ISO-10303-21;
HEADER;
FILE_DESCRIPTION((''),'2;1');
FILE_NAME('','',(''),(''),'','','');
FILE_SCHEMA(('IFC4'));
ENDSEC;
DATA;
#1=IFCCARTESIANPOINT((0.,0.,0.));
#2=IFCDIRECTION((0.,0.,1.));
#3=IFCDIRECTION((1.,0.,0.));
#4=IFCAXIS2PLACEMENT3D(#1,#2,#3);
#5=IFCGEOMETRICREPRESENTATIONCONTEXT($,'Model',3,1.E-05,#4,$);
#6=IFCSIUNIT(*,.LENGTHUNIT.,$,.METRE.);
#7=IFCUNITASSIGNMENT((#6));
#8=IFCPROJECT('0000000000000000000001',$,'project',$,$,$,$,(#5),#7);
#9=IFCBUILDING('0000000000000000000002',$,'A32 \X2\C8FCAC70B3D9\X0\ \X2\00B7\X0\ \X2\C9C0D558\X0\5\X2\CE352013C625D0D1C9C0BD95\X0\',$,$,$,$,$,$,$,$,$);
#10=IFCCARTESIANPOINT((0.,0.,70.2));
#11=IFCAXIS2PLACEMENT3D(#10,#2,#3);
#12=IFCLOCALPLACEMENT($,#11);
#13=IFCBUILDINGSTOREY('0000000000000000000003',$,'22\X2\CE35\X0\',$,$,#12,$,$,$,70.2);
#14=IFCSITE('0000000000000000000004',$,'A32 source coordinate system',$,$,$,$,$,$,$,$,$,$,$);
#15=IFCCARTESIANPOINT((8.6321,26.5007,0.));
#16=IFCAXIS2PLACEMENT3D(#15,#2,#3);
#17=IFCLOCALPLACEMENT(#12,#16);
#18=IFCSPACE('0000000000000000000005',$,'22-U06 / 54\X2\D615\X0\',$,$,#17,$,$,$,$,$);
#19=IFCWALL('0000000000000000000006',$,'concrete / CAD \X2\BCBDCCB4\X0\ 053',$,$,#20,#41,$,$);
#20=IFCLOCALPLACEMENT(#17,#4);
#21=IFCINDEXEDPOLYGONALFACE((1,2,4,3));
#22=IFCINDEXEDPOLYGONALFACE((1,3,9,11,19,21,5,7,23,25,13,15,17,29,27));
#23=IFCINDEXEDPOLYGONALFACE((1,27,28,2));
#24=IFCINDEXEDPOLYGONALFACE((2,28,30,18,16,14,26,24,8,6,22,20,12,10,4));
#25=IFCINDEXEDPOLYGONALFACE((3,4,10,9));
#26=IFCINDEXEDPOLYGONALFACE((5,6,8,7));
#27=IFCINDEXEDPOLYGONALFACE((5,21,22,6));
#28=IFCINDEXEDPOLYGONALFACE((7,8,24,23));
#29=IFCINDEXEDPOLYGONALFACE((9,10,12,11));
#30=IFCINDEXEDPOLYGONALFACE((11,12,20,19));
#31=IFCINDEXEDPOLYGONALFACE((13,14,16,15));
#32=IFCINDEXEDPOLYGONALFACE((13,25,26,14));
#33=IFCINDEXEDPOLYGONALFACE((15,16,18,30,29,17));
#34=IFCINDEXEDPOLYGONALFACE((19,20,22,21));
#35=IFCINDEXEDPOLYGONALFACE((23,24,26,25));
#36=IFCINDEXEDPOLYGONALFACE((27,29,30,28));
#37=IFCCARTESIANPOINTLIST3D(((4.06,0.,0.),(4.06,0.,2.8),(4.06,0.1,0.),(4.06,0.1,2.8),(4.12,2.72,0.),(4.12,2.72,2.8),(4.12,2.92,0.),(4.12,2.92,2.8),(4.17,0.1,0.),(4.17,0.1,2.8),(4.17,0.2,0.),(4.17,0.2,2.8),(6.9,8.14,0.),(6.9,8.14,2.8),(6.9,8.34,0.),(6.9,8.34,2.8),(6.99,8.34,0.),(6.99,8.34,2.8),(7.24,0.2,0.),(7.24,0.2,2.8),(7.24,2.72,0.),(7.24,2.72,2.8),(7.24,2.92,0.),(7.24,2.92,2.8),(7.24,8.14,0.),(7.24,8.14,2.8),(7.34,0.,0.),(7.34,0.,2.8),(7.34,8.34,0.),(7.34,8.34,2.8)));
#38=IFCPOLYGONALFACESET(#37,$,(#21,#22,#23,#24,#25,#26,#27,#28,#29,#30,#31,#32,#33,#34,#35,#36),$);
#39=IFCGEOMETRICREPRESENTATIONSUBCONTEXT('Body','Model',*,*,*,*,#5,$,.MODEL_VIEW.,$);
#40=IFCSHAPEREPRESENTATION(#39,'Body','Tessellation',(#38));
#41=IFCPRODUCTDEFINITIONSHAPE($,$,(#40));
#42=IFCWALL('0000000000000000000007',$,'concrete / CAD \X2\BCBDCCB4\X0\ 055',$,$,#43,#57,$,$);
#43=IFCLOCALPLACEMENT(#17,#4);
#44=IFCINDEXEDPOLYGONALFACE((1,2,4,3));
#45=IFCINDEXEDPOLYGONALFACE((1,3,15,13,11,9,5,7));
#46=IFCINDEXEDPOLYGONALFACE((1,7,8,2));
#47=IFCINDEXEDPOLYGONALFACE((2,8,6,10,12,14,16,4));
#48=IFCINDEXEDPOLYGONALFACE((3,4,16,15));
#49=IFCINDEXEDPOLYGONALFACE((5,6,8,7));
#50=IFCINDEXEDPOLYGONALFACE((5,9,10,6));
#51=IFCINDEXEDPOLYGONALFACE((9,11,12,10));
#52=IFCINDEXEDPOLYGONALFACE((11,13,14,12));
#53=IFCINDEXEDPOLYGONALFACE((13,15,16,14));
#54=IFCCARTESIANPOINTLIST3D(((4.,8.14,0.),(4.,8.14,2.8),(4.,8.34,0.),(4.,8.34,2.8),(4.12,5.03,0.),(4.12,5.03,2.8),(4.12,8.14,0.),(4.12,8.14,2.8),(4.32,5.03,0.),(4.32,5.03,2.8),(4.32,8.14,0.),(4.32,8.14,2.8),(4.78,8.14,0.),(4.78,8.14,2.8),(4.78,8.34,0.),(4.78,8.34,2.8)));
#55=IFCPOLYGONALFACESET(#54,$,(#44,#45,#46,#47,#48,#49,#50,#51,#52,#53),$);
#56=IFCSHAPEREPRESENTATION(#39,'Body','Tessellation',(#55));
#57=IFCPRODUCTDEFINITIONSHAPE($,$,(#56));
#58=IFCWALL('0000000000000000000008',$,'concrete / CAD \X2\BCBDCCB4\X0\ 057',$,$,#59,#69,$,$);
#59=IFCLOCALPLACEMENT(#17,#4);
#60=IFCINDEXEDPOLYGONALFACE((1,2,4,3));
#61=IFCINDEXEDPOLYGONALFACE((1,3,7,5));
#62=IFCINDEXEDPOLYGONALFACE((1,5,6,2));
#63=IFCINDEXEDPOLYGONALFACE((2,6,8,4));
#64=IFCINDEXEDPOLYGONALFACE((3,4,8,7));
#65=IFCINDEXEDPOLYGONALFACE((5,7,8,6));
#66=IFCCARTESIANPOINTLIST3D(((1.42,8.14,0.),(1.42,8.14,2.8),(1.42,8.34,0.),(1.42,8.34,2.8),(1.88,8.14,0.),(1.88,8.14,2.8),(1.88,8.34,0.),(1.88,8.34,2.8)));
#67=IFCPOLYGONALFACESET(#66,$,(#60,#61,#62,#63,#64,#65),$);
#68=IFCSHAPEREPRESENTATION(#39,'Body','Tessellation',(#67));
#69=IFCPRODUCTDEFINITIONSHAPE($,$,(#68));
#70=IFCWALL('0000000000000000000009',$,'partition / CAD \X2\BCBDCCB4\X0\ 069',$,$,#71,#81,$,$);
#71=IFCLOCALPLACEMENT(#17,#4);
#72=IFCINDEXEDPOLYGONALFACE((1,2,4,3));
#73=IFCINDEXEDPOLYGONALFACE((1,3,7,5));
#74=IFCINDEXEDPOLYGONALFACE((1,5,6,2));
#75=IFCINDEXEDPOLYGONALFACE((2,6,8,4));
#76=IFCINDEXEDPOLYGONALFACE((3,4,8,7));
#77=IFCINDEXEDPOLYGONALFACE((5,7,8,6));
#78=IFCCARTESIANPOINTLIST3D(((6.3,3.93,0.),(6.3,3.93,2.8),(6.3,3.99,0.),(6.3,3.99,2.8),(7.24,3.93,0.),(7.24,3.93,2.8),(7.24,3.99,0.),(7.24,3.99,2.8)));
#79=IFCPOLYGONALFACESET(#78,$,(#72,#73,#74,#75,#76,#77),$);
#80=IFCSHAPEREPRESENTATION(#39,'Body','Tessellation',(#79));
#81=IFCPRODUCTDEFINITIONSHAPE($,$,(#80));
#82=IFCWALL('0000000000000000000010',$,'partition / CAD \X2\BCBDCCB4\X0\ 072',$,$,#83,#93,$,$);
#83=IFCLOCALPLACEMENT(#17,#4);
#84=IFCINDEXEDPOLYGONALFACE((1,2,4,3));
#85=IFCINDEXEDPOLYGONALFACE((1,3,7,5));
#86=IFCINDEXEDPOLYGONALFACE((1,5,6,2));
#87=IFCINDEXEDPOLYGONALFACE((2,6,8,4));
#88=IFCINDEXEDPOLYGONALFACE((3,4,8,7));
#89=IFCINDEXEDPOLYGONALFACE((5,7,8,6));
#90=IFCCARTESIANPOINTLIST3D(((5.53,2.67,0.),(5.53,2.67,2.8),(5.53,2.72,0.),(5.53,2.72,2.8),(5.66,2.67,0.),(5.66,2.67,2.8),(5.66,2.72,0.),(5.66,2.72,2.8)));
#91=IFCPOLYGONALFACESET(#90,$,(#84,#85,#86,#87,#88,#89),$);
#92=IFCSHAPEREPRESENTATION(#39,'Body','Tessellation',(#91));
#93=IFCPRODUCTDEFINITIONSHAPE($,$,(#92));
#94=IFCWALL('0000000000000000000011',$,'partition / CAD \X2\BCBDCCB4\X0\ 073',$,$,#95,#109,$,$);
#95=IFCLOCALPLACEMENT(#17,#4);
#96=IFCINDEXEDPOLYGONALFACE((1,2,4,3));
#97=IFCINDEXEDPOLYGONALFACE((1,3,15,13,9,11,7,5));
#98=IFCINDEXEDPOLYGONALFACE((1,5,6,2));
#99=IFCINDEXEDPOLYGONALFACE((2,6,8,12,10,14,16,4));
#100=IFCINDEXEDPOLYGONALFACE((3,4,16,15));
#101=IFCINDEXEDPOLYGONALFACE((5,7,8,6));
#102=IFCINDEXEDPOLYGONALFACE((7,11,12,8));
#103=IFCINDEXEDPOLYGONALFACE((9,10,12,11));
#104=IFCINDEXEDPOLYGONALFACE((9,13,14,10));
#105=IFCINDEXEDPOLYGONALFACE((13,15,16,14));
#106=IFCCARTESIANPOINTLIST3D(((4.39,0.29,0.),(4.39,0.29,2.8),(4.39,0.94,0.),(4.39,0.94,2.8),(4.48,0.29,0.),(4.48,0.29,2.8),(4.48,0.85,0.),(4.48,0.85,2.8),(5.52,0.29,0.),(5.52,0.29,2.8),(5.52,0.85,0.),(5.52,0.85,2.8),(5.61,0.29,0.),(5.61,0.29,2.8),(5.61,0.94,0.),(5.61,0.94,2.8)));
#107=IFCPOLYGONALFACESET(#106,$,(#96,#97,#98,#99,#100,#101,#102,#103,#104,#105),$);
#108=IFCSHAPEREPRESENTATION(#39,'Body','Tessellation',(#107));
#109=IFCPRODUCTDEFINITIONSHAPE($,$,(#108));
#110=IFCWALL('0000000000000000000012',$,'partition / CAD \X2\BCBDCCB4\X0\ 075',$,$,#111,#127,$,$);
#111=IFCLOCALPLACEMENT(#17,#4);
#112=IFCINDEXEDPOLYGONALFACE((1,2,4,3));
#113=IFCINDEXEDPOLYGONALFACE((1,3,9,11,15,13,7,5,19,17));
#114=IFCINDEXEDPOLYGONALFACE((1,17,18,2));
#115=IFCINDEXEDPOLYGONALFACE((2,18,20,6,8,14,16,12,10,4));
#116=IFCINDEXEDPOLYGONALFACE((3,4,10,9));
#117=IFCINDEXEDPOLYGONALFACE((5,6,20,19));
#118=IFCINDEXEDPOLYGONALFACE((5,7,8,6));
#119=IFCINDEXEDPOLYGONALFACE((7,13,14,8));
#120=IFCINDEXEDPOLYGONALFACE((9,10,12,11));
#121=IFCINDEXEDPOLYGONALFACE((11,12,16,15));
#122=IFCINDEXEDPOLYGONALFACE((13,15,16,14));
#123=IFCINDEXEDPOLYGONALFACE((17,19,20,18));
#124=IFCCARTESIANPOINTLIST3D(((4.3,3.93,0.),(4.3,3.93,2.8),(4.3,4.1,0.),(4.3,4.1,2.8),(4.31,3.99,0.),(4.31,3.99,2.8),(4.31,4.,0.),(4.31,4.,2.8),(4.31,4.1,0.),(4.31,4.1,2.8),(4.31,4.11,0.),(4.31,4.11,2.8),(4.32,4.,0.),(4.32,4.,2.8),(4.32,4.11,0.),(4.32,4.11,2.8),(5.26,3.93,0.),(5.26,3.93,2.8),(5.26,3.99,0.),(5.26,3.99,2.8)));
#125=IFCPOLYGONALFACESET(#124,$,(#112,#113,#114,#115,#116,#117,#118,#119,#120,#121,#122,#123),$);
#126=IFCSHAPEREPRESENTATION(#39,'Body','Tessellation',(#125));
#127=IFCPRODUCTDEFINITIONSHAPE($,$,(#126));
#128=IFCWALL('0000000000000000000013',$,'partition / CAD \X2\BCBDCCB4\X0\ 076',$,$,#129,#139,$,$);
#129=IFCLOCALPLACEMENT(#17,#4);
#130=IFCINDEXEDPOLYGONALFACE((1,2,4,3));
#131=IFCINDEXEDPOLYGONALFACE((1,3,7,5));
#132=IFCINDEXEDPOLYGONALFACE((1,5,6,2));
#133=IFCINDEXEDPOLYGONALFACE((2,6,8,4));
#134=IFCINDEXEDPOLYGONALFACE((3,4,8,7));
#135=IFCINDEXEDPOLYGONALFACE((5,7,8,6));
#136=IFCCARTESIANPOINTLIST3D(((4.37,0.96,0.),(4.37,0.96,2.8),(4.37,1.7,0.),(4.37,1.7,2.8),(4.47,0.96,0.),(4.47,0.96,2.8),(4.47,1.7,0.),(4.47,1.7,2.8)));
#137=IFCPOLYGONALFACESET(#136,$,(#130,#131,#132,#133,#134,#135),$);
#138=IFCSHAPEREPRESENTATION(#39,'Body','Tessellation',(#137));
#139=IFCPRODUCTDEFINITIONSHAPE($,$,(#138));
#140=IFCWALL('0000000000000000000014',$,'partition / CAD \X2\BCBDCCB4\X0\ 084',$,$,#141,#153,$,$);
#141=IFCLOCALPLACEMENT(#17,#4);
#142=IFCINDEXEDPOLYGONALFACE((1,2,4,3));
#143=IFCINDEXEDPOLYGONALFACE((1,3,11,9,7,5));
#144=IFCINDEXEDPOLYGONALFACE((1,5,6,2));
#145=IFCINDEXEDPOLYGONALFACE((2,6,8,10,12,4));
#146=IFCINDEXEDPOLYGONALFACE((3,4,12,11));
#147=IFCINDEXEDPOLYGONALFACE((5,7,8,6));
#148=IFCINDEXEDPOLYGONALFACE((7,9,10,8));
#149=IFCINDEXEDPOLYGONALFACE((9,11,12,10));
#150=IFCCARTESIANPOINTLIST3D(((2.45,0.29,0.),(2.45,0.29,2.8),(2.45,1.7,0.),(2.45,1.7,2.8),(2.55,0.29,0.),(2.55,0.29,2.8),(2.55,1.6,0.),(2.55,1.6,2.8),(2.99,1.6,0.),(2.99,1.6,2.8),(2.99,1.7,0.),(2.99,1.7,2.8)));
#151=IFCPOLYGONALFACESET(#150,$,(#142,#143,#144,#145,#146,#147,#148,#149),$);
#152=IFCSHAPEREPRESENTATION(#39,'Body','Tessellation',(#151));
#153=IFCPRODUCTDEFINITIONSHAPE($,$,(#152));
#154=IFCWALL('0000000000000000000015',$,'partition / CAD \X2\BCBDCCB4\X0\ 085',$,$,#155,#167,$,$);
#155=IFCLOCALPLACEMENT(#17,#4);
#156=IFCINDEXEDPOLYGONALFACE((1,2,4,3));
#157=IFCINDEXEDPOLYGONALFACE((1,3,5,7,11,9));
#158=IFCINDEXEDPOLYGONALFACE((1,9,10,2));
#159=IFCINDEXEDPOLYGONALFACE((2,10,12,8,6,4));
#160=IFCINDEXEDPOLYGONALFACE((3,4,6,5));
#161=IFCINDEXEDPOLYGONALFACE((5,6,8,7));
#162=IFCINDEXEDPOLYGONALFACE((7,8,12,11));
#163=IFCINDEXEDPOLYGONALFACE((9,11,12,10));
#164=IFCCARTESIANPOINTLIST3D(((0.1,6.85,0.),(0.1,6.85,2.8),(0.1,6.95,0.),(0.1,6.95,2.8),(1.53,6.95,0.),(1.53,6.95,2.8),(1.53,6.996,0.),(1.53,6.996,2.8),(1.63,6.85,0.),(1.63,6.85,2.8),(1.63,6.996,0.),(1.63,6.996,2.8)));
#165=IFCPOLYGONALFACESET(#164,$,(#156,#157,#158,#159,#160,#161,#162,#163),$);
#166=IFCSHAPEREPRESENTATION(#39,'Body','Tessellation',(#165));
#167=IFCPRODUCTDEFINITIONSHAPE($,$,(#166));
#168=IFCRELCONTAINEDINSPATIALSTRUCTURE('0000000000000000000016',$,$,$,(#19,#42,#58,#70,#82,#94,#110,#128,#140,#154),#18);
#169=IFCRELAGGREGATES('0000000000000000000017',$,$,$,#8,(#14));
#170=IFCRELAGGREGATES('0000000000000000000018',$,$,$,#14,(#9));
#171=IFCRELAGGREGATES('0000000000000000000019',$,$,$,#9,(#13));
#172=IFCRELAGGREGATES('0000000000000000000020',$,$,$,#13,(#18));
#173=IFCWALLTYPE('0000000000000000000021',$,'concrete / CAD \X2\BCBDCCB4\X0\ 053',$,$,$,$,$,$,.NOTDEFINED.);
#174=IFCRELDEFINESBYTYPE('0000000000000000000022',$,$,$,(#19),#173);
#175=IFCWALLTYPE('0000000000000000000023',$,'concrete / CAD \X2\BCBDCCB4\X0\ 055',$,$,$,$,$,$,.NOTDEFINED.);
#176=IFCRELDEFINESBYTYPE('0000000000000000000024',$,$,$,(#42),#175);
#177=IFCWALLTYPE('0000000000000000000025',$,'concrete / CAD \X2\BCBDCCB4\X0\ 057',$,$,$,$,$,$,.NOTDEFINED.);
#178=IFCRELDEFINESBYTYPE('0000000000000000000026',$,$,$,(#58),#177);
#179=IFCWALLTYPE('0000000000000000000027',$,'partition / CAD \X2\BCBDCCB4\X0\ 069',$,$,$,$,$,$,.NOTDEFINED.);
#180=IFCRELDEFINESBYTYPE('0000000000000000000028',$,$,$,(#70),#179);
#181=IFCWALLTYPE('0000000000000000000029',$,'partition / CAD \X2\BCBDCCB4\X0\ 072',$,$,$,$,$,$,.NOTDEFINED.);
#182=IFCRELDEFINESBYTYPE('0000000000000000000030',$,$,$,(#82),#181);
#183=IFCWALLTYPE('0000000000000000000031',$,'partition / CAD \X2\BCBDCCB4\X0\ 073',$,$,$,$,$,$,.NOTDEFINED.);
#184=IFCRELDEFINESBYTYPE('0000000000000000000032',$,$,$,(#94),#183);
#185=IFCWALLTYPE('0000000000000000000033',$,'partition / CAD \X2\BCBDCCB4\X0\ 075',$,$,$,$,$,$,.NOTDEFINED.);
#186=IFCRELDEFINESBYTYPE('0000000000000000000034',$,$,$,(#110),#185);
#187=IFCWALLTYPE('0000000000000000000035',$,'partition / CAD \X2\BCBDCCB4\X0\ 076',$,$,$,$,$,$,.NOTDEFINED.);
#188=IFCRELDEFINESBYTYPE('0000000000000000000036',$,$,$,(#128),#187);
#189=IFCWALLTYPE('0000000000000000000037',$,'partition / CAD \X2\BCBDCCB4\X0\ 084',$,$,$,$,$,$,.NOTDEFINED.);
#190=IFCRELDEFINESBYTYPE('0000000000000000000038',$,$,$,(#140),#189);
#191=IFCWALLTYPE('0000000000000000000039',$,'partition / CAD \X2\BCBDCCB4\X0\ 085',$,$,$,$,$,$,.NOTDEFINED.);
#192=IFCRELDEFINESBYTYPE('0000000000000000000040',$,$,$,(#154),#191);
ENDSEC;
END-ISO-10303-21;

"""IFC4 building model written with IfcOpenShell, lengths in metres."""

from ifc_helpers import new_model, si_unit, frame, origin, origin_with_axes, place, context, subcontext, project, spatial, polyline, outline, extrude, source, transform, mapped, type_object, type_shapes, element, save


model = new_model("IFC4")

# Units and contexts
model_context = context("Model", 3, precision=1e-05, world=origin_with_axes())
body_context = subcontext(model_context, "Body", "Model", "MODEL_VIEW")
ifc_project = project(units=[si_unit("LENGTHUNIT", "METRE")], contexts=[model_context])

# Site, building, storey, space
site = spatial("IfcSite", under=ifc_project, Name="A32 source coordinate system")
building = spatial("IfcBuilding", under=site, Name="A32 주거동 · 지하5층–옥탑지붕")
storey_placement = place(None, frame((0.0, 0.0, 70.2), z_axis=(0.0, 0.0, 1.0), x_axis=(1.0, 0.0, 0.0)))
storey = spatial("IfcBuildingStorey", under=building, at=storey_placement, Name="22층", Elevation=70.2)
space_placement = place(storey_placement, frame((8.6321, 26.5007, 0.0), z_axis=(0.0, 0.0, 1.0), x_axis=(1.0, 0.0, 0.0)))
space = spatial("IfcSpace", under=storey, at=space_placement, Name="22-U06 / 54형")

# Walls
wall_type_1 = type_object("IfcWallType", Name="concrete / CAD 벽체 053", PredefinedType="NOTDEFINED")
shared_shape_1 = source(origin(), body_context, "Body", "SweptSolid", [
    extrude(outline(polyline([(7.24, 8.14), (6.9, 8.14), (6.9, 8.34), (6.99, 8.34), (6.99, 8.34), (7.34, 8.34), (7.34, 8.34), (7.34, 0.0), (4.06, 0.0), (4.06, 0.1), (4.17, 0.1), (4.17, 0.2), (7.24, 0.2), (7.24, 2.72), (4.12, 2.72), (4.12, 2.92), (7.24, 2.92), (7.24, 8.14)])), origin(), (0.0, 0.0, 1.0), 2.8),
])
type_shapes(wall_type_1, [shared_shape_1])
wall_1_placement = place(space_placement, origin_with_axes())
element("IfcWall", 1, at=wall_1_placement, inside=space, type_object=wall_type_1, Name="concrete / CAD 벽체 053", context=body_context, shape_type="MappedRepresentation", body=[
    mapped(shared_shape_1, transform((0.0, 0.0, 0.0), scale=1.0)),
])
wall_type_2 = type_object("IfcWallType", Name="concrete / CAD 벽체 055", PredefinedType="NOTDEFINED")
shared_shape_2 = source(origin(), body_context, "Body", "SweptSolid", [
    extrude(outline(polyline([(4.32, 5.03), (4.12, 5.03), (4.12, 8.14), (4.0, 8.14), (4.0, 8.34), (4.78, 8.34), (4.78, 8.14), (4.32, 8.14), (4.32, 5.03)])), origin(), (0.0, 0.0, 1.0), 2.8),
])
type_shapes(wall_type_2, [shared_shape_2])
wall_2_placement = place(space_placement, origin_with_axes())
element("IfcWall", 2, at=wall_2_placement, inside=space, type_object=wall_type_2, Name="concrete / CAD 벽체 055", context=body_context, shape_type="MappedRepresentation", body=[
    mapped(shared_shape_2, transform((0.0, 0.0, 0.0), scale=1.0)),
])
wall_type_3 = type_object("IfcWallType", Name="concrete / CAD 벽체 057", PredefinedType="NOTDEFINED")
shared_shape_3 = source(origin(), body_context, "Body", "SweptSolid", [
    extrude(outline(polyline([(1.42, 8.14), (1.42, 8.34), (1.88, 8.34), (1.88, 8.14), (1.42, 8.14)])), origin(), (0.0, 0.0, 1.0), 2.8),
])
type_shapes(wall_type_3, [shared_shape_3])
wall_3_placement = place(space_placement, origin_with_axes())
element("IfcWall", 3, at=wall_3_placement, inside=space, type_object=wall_type_3, Name="concrete / CAD 벽체 057", context=body_context, shape_type="MappedRepresentation", body=[
    mapped(shared_shape_3, transform((0.0, 0.0, 0.0), scale=1.0)),
])
wall_type_4 = type_object("IfcWallType", Name="partition / CAD 벽체 069", PredefinedType="NOTDEFINED")
shared_shape_4 = source(origin(), body_context, "Body", "SweptSolid", [
    extrude(outline(polyline([(7.24, 3.93), (6.3, 3.93), (6.3, 3.99), (7.24, 3.99), (7.24, 3.93)])), origin(), (0.0, 0.0, 1.0), 2.8),
])
type_shapes(wall_type_4, [shared_shape_4])
wall_4_placement = place(space_placement, origin_with_axes())
element("IfcWall", 4, at=wall_4_placement, inside=space, type_object=wall_type_4, Name="partition / CAD 벽체 069", context=body_context, shape_type="MappedRepresentation", body=[
    mapped(shared_shape_4, transform((0.0, 0.0, 0.0), scale=1.0)),
])
wall_type_5 = type_object("IfcWallType", Name="partition / CAD 벽체 072", PredefinedType="NOTDEFINED")
shared_shape_5 = source(origin(), body_context, "Body", "SweptSolid", [
    extrude(outline(polyline([(5.66, 2.67), (5.53, 2.67), (5.53, 2.72), (5.66, 2.72), (5.66, 2.67)])), origin(), (0.0, 0.0, 1.0), 2.8),
])
type_shapes(wall_type_5, [shared_shape_5])
wall_5_placement = place(space_placement, origin_with_axes())
element("IfcWall", 5, at=wall_5_placement, inside=space, type_object=wall_type_5, Name="partition / CAD 벽체 072", context=body_context, shape_type="MappedRepresentation", body=[
    mapped(shared_shape_5, transform((0.0, 0.0, 0.0), scale=1.0)),
])
wall_type_6 = type_object("IfcWallType", Name="partition / CAD 벽체 073", PredefinedType="NOTDEFINED")
shared_shape_6 = source(origin(), body_context, "Body", "SweptSolid", [
    extrude(outline(polyline([(4.48, 0.29), (4.39, 0.29), (4.39, 0.94), (5.61, 0.94), (5.61, 0.29), (5.52, 0.29), (5.52, 0.85), (4.48, 0.85), (4.48, 0.29)])), origin(), (0.0, 0.0, 1.0), 2.8),
])
type_shapes(wall_type_6, [shared_shape_6])
wall_6_placement = place(space_placement, origin_with_axes())
element("IfcWall", 6, at=wall_6_placement, inside=space, type_object=wall_type_6, Name="partition / CAD 벽체 073", context=body_context, shape_type="MappedRepresentation", body=[
    mapped(shared_shape_6, transform((0.0, 0.0, 0.0), scale=1.0)),
])
wall_type_7 = type_object("IfcWallType", Name="partition / CAD 벽체 075", PredefinedType="NOTDEFINED")
shared_shape_7 = source(origin(), body_context, "Body", "SweptSolid", [
    extrude(outline(polyline([(4.32, 4.0), (4.31, 4.0), (4.31, 3.99), (5.26, 3.99), (5.26, 3.93), (4.3, 3.93), (4.3, 4.1), (4.31, 4.1), (4.31, 4.11), (4.32, 4.11), (4.32, 4.0)])), origin(), (0.0, 0.0, 1.0), 2.8),
])
type_shapes(wall_type_7, [shared_shape_7])
wall_7_placement = place(space_placement, origin_with_axes())
element("IfcWall", 7, at=wall_7_placement, inside=space, type_object=wall_type_7, Name="partition / CAD 벽체 075", context=body_context, shape_type="MappedRepresentation", body=[
    mapped(shared_shape_7, transform((0.0, 0.0, 0.0), scale=1.0)),
])
wall_type_8 = type_object("IfcWallType", Name="partition / CAD 벽체 076", PredefinedType="NOTDEFINED")
shared_shape_8 = source(origin(), body_context, "Body", "SweptSolid", [
    extrude(outline(polyline([(4.37, 1.7), (4.47, 1.7), (4.47, 0.96), (4.37, 0.96), (4.37, 1.7)])), origin(), (0.0, 0.0, 1.0), 2.8),
])
type_shapes(wall_type_8, [shared_shape_8])
wall_8_placement = place(space_placement, origin_with_axes())
element("IfcWall", 8, at=wall_8_placement, inside=space, type_object=wall_type_8, Name="partition / CAD 벽체 076", context=body_context, shape_type="MappedRepresentation", body=[
    mapped(shared_shape_8, transform((0.0, 0.0, 0.0), scale=1.0)),
])
wall_type_9 = type_object("IfcWallType", Name="partition / CAD 벽체 084", PredefinedType="NOTDEFINED")
shared_shape_9 = source(origin(), body_context, "Body", "SweptSolid", [
    extrude(outline(polyline([(2.99, 1.6), (2.55, 1.6), (2.55, 0.29), (2.45, 0.29), (2.45, 1.7), (2.99, 1.7), (2.99, 1.6)])), origin(), (0.0, 0.0, 1.0), 2.8),
])
type_shapes(wall_type_9, [shared_shape_9])
wall_9_placement = place(space_placement, origin_with_axes())
element("IfcWall", 9, at=wall_9_placement, inside=space, type_object=wall_type_9, Name="partition / CAD 벽체 084", context=body_context, shape_type="MappedRepresentation", body=[
    mapped(shared_shape_9, transform((0.0, 0.0, 0.0), scale=1.0)),
])
wall_type_10 = type_object("IfcWallType", Name="partition / CAD 벽체 085", PredefinedType="NOTDEFINED")
shared_shape_10 = source(origin(), body_context, "Body", "SweptSolid", [
    extrude(outline(polyline([(1.63, 6.85), (0.1, 6.85), (0.1, 6.95), (1.53, 6.95), (1.53, 6.996), (1.63, 6.996), (1.63, 6.85)])), origin(), (0.0, 0.0, 1.0), 2.8),
])
type_shapes(wall_type_10, [shared_shape_10])
wall_10_placement = place(space_placement, origin_with_axes())
element("IfcWall", 10, at=wall_10_placement, inside=space, type_object=wall_type_10, Name="partition / CAD 벽체 085", context=body_context, shape_type="MappedRepresentation", body=[
    mapped(shared_shape_10, transform((0.0, 0.0, 0.0), scale=1.0)),
])

save(model, "model.ifc")
